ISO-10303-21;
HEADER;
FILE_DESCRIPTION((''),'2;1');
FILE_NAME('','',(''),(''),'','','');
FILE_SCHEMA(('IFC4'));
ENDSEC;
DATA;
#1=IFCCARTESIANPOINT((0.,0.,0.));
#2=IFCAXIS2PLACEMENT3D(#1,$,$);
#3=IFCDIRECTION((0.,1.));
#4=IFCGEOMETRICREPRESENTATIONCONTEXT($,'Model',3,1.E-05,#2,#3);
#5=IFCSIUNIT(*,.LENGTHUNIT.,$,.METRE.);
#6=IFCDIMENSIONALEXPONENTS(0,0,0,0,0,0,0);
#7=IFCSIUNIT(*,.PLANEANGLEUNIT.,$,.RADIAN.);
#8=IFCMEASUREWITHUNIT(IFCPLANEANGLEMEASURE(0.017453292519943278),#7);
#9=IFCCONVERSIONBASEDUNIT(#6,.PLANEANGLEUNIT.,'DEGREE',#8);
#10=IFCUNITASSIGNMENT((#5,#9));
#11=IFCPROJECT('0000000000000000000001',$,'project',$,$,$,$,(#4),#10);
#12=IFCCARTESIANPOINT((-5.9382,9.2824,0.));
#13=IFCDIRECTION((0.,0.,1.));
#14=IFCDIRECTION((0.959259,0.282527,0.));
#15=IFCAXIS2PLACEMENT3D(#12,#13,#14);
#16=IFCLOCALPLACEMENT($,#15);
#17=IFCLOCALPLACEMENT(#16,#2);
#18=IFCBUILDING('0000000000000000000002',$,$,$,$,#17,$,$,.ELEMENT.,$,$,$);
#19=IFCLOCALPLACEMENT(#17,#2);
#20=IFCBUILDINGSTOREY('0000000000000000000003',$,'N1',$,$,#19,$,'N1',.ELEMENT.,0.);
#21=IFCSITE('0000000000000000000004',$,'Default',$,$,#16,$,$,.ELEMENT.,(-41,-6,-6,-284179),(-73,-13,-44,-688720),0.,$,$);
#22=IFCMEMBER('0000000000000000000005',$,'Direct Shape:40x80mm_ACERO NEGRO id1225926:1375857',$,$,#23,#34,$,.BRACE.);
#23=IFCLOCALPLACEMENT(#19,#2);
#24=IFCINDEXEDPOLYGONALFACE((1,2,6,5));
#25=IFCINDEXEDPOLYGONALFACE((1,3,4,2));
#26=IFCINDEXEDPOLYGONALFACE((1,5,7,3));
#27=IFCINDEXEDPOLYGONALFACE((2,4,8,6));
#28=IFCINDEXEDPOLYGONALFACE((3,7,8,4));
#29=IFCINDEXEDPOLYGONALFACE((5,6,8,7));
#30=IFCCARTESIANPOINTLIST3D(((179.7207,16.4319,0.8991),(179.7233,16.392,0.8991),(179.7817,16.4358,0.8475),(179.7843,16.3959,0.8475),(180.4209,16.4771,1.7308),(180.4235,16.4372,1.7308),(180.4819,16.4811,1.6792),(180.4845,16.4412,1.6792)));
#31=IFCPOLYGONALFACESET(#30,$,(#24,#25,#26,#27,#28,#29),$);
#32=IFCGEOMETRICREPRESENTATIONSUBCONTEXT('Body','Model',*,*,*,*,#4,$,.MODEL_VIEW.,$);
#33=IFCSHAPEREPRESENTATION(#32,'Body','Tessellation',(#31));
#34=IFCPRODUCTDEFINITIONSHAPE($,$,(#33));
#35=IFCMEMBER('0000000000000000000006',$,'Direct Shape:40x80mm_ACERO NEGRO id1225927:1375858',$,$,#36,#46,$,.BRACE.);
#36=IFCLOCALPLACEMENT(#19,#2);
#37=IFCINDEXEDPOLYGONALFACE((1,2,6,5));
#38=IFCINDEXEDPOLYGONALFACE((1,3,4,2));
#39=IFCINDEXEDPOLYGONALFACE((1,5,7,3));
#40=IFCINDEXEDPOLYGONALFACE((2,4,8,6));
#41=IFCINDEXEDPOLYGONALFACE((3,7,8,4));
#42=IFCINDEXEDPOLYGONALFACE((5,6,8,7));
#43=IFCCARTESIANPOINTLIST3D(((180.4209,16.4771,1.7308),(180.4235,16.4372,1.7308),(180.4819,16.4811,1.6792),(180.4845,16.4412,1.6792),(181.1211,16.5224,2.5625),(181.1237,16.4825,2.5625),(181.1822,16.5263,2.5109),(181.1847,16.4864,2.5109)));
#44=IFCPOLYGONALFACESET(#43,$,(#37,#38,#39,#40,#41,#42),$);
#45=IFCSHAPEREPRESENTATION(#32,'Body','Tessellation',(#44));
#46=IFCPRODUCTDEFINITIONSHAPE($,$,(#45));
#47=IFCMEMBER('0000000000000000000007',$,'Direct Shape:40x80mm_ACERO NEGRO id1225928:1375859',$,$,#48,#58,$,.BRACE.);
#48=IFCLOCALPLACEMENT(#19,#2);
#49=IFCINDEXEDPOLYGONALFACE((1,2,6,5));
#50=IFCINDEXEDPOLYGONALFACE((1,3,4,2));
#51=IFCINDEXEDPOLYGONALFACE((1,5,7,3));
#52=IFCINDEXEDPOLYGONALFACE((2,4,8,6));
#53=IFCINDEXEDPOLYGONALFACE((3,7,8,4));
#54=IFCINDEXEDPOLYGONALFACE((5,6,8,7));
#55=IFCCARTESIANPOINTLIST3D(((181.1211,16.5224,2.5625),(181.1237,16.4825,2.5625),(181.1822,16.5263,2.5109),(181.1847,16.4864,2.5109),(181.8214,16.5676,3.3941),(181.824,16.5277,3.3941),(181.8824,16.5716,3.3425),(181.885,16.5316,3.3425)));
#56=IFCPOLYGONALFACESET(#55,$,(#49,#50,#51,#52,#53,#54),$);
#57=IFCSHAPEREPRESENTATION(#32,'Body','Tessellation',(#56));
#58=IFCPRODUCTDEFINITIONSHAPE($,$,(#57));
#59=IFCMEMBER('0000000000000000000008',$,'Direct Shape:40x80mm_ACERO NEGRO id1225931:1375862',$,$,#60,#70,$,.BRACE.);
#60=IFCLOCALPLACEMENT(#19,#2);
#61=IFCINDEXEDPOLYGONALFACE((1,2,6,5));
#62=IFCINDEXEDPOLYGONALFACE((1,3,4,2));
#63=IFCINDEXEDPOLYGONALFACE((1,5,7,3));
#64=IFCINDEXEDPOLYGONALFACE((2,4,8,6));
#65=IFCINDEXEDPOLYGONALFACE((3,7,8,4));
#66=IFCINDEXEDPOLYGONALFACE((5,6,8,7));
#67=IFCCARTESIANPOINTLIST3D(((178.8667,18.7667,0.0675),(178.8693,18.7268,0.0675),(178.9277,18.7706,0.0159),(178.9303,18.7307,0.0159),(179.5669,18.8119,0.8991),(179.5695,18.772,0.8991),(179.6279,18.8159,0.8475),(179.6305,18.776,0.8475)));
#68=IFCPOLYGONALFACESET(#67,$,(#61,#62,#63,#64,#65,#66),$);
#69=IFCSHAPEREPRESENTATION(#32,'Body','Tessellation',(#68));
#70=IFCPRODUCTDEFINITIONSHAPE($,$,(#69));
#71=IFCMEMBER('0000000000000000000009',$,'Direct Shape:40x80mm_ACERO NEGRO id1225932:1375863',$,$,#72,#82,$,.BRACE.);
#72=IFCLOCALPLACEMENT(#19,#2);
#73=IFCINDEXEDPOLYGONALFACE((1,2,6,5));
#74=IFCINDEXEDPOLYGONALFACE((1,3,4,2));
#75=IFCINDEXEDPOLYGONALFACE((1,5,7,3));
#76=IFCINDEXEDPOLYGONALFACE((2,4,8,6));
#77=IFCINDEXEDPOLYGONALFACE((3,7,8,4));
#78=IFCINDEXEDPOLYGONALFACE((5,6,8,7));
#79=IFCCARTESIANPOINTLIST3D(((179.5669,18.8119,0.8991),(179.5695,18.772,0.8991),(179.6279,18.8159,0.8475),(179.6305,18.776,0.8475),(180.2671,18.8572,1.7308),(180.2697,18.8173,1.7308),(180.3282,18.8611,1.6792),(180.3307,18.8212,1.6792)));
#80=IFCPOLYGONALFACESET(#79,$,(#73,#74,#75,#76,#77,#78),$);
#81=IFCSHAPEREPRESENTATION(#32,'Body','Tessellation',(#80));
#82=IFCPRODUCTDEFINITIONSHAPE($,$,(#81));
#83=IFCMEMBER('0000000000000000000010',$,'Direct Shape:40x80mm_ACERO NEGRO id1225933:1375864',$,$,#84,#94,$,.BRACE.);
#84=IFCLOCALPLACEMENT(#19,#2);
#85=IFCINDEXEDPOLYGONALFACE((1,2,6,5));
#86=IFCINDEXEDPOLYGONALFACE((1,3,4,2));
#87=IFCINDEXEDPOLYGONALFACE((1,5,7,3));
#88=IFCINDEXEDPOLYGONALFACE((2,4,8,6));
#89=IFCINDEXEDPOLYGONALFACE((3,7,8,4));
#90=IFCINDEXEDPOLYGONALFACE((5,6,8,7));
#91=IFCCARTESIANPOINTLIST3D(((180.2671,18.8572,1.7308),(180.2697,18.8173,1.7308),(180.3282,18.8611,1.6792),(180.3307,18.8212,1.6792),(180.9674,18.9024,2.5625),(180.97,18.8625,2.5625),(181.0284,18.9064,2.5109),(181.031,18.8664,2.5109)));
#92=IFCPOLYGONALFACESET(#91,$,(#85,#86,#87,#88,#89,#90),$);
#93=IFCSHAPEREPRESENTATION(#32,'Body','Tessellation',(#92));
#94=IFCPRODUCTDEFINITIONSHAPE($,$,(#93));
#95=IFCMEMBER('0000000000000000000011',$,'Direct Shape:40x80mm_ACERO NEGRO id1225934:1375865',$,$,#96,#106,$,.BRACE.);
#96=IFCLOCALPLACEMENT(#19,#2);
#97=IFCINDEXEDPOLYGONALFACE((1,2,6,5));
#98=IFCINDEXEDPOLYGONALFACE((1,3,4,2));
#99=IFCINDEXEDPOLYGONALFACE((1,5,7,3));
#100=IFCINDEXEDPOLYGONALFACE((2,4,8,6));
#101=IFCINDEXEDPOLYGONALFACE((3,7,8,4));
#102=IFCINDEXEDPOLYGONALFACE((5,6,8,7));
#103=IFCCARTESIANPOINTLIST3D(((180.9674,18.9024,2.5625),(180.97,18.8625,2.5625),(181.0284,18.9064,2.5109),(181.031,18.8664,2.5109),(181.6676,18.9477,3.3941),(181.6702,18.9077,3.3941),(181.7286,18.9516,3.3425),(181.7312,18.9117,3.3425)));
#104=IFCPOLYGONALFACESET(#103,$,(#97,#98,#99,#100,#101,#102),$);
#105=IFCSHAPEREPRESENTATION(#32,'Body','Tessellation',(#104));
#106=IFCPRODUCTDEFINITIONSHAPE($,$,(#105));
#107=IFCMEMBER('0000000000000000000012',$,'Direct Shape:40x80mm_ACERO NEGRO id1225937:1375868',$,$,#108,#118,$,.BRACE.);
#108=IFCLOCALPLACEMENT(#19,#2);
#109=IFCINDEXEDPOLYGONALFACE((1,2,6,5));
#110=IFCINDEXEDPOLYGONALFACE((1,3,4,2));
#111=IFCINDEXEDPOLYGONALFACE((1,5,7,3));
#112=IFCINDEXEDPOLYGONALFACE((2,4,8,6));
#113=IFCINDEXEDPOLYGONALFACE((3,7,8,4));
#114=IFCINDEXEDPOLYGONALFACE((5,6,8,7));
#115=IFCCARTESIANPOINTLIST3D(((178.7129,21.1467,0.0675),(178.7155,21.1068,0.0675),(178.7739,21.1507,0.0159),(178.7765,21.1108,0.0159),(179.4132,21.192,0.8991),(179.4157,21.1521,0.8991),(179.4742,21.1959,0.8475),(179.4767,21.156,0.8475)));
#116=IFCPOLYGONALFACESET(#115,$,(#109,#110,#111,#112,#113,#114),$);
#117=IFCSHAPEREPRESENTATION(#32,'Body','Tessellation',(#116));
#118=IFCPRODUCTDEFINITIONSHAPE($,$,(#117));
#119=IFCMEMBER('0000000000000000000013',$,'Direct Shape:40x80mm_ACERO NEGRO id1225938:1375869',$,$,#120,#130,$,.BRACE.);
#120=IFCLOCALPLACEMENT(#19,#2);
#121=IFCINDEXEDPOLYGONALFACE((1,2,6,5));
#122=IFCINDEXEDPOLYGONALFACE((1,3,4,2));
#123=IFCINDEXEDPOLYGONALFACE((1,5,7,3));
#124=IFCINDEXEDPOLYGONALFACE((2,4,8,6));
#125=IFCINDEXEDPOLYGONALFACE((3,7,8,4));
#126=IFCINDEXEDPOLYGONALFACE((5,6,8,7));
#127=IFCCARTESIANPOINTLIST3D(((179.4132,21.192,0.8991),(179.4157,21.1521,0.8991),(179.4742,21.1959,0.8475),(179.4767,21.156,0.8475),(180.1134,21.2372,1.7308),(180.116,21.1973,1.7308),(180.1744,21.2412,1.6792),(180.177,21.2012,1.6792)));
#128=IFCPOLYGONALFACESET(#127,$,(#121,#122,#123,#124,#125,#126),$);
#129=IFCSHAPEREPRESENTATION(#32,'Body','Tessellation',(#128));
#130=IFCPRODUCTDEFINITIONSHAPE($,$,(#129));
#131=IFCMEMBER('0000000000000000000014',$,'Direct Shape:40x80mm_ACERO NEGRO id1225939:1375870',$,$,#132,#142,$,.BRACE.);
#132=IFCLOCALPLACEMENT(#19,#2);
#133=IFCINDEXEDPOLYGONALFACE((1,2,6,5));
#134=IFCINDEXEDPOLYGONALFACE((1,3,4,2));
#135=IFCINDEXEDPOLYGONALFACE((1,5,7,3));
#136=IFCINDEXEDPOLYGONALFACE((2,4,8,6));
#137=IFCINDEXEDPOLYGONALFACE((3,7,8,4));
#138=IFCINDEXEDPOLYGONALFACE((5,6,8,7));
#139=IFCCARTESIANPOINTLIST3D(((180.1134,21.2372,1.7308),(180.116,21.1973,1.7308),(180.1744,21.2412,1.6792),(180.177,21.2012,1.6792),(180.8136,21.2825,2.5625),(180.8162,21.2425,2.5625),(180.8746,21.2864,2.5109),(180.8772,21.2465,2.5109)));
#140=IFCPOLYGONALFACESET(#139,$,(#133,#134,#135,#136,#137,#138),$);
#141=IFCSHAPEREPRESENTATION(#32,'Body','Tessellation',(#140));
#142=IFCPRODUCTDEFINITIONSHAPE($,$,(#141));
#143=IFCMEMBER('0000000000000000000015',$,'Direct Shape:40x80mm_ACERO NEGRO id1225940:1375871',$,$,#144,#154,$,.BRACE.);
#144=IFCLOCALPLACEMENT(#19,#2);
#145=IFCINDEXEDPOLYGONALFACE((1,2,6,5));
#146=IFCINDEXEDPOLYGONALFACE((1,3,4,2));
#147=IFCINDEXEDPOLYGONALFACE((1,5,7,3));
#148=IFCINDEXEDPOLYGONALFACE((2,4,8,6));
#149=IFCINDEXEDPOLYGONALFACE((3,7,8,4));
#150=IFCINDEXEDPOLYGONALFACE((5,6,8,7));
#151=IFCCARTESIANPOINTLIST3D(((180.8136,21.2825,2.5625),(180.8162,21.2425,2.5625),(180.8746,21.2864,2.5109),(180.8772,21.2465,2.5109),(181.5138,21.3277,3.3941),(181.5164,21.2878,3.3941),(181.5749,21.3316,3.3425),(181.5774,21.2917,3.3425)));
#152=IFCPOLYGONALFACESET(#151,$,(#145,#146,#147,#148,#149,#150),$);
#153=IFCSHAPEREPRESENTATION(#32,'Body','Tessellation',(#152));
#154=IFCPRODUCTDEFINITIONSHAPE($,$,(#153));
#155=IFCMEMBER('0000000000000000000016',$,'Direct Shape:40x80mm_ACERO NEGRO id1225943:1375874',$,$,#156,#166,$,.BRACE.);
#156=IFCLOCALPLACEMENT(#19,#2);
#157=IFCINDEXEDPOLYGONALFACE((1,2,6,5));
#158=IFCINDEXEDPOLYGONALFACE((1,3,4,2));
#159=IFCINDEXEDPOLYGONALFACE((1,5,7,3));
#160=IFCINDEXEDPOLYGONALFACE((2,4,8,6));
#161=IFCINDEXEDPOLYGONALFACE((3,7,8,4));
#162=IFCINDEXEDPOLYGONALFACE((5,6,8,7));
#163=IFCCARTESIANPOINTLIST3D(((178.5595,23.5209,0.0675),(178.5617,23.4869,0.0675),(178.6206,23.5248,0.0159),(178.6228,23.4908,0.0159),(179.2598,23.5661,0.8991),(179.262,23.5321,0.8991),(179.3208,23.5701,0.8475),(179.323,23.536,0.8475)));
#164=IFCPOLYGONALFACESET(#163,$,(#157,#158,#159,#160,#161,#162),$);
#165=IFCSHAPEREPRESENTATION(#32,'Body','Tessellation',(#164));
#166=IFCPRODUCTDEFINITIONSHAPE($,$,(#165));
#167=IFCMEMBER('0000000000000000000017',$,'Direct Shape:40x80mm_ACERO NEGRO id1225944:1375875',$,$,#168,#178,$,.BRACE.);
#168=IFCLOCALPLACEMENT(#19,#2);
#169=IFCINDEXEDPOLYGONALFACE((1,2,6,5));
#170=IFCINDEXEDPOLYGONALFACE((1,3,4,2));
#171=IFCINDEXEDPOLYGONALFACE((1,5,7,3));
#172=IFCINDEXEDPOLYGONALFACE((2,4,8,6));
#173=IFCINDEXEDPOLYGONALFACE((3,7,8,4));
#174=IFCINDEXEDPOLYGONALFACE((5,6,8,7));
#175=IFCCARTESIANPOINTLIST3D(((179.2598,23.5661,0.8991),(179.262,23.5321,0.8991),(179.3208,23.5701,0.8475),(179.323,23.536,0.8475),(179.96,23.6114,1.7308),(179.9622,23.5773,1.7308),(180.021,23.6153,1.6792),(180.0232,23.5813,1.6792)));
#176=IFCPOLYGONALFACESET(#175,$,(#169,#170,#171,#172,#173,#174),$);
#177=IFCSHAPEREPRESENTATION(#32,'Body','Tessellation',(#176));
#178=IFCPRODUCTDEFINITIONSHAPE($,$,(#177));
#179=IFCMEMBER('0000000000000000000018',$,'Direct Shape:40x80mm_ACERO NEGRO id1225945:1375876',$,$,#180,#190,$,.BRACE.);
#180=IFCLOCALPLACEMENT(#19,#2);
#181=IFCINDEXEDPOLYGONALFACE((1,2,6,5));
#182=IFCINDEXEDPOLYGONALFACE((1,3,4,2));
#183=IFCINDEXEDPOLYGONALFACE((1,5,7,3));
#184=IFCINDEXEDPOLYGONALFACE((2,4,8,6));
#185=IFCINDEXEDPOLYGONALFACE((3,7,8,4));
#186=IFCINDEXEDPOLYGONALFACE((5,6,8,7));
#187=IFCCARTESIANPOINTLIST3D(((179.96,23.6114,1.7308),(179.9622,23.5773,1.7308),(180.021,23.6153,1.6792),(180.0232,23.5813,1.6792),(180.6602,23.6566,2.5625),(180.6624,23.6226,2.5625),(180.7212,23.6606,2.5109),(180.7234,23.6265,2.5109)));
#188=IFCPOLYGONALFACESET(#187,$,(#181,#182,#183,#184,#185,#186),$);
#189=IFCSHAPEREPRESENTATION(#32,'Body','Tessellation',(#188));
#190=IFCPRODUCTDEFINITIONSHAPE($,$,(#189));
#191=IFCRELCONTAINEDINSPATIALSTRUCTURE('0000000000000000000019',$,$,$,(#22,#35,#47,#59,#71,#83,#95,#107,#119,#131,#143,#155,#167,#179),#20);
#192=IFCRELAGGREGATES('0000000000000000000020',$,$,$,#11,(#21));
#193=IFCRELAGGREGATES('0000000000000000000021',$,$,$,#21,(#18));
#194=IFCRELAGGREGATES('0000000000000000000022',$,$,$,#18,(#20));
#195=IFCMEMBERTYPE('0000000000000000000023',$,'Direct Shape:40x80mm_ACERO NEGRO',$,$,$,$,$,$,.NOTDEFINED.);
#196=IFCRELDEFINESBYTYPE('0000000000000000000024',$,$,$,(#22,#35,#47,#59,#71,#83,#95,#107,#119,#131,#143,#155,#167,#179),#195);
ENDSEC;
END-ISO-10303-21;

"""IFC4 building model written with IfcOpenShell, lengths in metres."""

from ifc_helpers import new_model, entity, si_unit, converted_unit, direction, frame, frame_2d, origin, place, context, subcontext, project, spatial, rectangle, extrude, type_object, element, save


model = new_model("IFC4")

# Units and contexts
model_context = context("Model", 3, precision=1e-05, world=origin(), true_north=direction((0.0, 1.0)))
body_context = subcontext(model_context, "Body", "Model", "MODEL_VIEW")
ifc_project = project(units=[si_unit("LENGTHUNIT", "METRE"), converted_unit("PLANEANGLEUNIT", "DEGREE", entity("IfcPlaneAngleMeasure", 0.017453292519943278), si_unit("PLANEANGLEUNIT", "RADIAN"), dimensions=[0, 0, 0, 0, 0, 0, 0])], contexts=[model_context])

# Site, building, storey
site_placement = place(None, frame((-5.9382, 9.2824, 0.0), z_axis=(0.0, 0.0, 1.0), x_axis=(0.959259, 0.282527, 0.0)))
site = spatial("IfcSite", under=ifc_project, at=site_placement, Name="Default", CompositionType="ELEMENT", RefLatitude=(-41, -6, -6, -284179), RefLongitude=(-73, -13, -44, -688720), RefElevation=0.0)
building_placement = place(site_placement, origin())
building = spatial("IfcBuilding", under=site, at=building_placement, CompositionType="ELEMENT")
storey_placement = place(building_placement, origin())
storey = spatial("IfcBuildingStorey", under=building, at=storey_placement, Name="N1", LongName="N1", CompositionType="ELEMENT", Elevation=0.0)

# Members
member_type_1 = type_object("IfcMemberType", Name="Direct Shape:40x80mm_ACERO NEGRO", PredefinedType="NOTDEFINED")
member_1_placement = place(storey_placement, origin())
element("IfcMember", 1, at=member_1_placement, inside=storey, type_object=member_type_1, Name="Direct Shape:40x80mm_ACERO NEGRO id1225926:1375857", PredefinedType="BRACE", context=body_context, shape_type="SweptSolid", body=[
    extrude(rectangle(XDim=0.08, YDim=0.04, at=frame_2d((0.0, 0.0), x_axis=(0.0, 1.0))), frame((179.7525, 16.4139, 0.8733), z_axis=(0.643515, 0.041575, 0.764304), x_axis=(0.064471, -0.99792, 0.0)), (0.0, 0.0, 1.0), 1.0881),
])
member_2_placement = place(storey_placement, origin())
element("IfcMember", 2, at=member_2_placement, inside=storey, type_object=member_type_1, Name="Direct Shape:40x80mm_ACERO NEGRO id1225927:1375858", PredefinedType="BRACE", context=body_context, shape_type="SweptSolid", body=[
    extrude(rectangle(XDim=0.08, YDim=0.04, at=frame_2d((0.0, 0.0), x_axis=(0.0, 1.0))), frame((180.4527, 16.4592, 1.705), z_axis=(0.643515, 0.041575, 0.764304), x_axis=(0.064471, -0.99792, 0.0)), (0.0, 0.0, 1.0), 1.0881),
])
member_3_placement = place(storey_placement, origin())
element("IfcMember", 3, at=member_3_placement, inside=storey, type_object=member_type_1, Name="Direct Shape:40x80mm_ACERO NEGRO id1225928:1375859", PredefinedType="BRACE", context=body_context, shape_type="SweptSolid", body=[
    extrude(rectangle(XDim=0.08, YDim=0.04, at=frame_2d((0.0, 0.0), x_axis=(0.0, 1.0))), frame((181.1529, 16.5044, 2.5367), z_axis=(0.643515, 0.041575, 0.764304), x_axis=(0.064471, -0.99792, 0.0)), (0.0, 0.0, 1.0), 1.0881),
])
member_4_placement = place(storey_placement, origin())
element("IfcMember", 4, at=member_4_placement, inside=storey, type_object=member_type_1, Name="Direct Shape:40x80mm_ACERO NEGRO id1225931:1375862", PredefinedType="BRACE", context=body_context, shape_type="SweptSolid", body=[
    extrude(rectangle(XDim=0.08, YDim=0.04, at=frame_2d((0.0, 0.0), x_axis=(0.0, 1.0))), frame((178.8985, 18.7487, 0.0417), z_axis=(0.643515, 0.041575, 0.764304), x_axis=(0.064471, -0.99792, 0.0)), (0.0, 0.0, 1.0), 1.0881),
])
member_5_placement = place(storey_placement, origin())
element("IfcMember", 5, at=member_5_placement, inside=storey, type_object=member_type_1, Name="Direct Shape:40x80mm_ACERO NEGRO id1225932:1375863", PredefinedType="BRACE", context=body_context, shape_type="SweptSolid", body=[
    extrude(rectangle(XDim=0.08, YDim=0.04, at=frame_2d((0.0, 0.0), x_axis=(0.0, 1.0))), frame((179.5987, 18.794, 0.8733), z_axis=(0.643515, 0.041575, 0.764304), x_axis=(0.064471, -0.99792, 0.0)), (0.0, 0.0, 1.0), 1.0881),
])
member_6_placement = place(storey_placement, origin())
element("IfcMember", 6, at=member_6_placement, inside=storey, type_object=member_type_1, Name="Direct Shape:40x80mm_ACERO NEGRO id1225933:1375864", PredefinedType="BRACE", context=body_context, shape_type="SweptSolid", body=[
    extrude(rectangle(XDim=0.08, YDim=0.04, at=frame_2d((0.0, 0.0), x_axis=(0.0, 1.0))), frame((180.2989, 18.8392, 1.705), z_axis=(0.643515, 0.041575, 0.764304), x_axis=(0.064471, -0.99792, 0.0)), (0.0, 0.0, 1.0), 1.0881),
])
member_7_placement = place(storey_placement, origin())
element("IfcMember", 7, at=member_7_placement, inside=storey, type_object=member_type_1, Name="Direct Shape:40x80mm_ACERO NEGRO id1225934:1375865", PredefinedType="BRACE", context=body_context, shape_type="SweptSolid", body=[
    extrude(rectangle(XDim=0.08, YDim=0.04, at=frame_2d((0.0, 0.0), x_axis=(0.0, 1.0))), frame((180.9992, 18.8844, 2.5367), z_axis=(0.643515, 0.041575, 0.764304), x_axis=(0.064471, -0.99792, 0.0)), (0.0, 0.0, 1.0), 1.0881),
])
member_8_placement = place(storey_placement, origin())
element("IfcMember", 8, at=member_8_placement, inside=storey, type_object=member_type_1, Name="Direct Shape:40x80mm_ACERO NEGRO id1225937:1375868", PredefinedType="BRACE", context=body_context, shape_type="SweptSolid", body=[
    extrude(rectangle(XDim=0.08, YDim=0.04, at=frame_2d((0.0, 0.0), x_axis=(0.0, 1.0))), frame((178.7447, 21.1288, 0.0417), z_axis=(0.643515, 0.041575, 0.764304), x_axis=(0.064471, -0.99792, 0.0)), (0.0, 0.0, 1.0), 1.0881),
])
member_9_placement = place(storey_placement, origin())
element("IfcMember", 9, at=member_9_placement, inside=storey, type_object=member_type_1, Name="Direct Shape:40x80mm_ACERO NEGRO id1225938:1375869", PredefinedType="BRACE", context=body_context, shape_type="SweptSolid", body=[
    extrude(rectangle(XDim=0.08, YDim=0.04, at=frame_2d((0.0, 0.0), x_axis=(0.0, 1.0))), frame((179.4449, 21.174, 0.8733), z_axis=(0.643515, 0.041575, 0.764304), x_axis=(0.064471, -0.99792, 0.0)), (0.0, 0.0, 1.0), 1.0881),
])
member_10_placement = place(storey_placement, origin())
element("IfcMember", 10, at=member_10_placement, inside=storey, type_object=member_type_1, Name="Direct Shape:40x80mm_ACERO NEGRO id1225939:1375870", PredefinedType="BRACE", context=body_context, shape_type="SweptSolid", body=[
    extrude(rectangle(XDim=0.08, YDim=0.04, at=frame_2d((0.0, 0.0), x_axis=(0.0, 1.0))), frame((180.1452, 21.2192, 1.705), z_axis=(0.643515, 0.041575, 0.764304), x_axis=(0.064471, -0.99792, 0.0)), (0.0, 0.0, 1.0), 1.0881),
])
member_11_placement = place(storey_placement, origin())
element("IfcMember", 11, at=member_11_placement, inside=storey, type_object=member_type_1, Name="Direct Shape:40x80mm_ACERO NEGRO id1225940:1375871", PredefinedType="BRACE", context=body_context, shape_type="SweptSolid", body=[
    extrude(rectangle(XDim=0.08, YDim=0.04, at=frame_2d((0.0, 0.0), x_axis=(0.0, 1.0))), frame((180.8454, 21.2645, 2.5367), z_axis=(0.643515, 0.041575, 0.764304), x_axis=(0.064471, -0.99792, 0.0)), (0.0, 0.0, 1.0), 1.0881),
])
member_12_placement = place(storey_placement, origin())
element("IfcMember", 12, at=member_12_placement, inside=storey, type_object=member_type_1, Name="Direct Shape:40x80mm_ACERO NEGRO id1225943:1375874", PredefinedType="BRACE", context=body_context, shape_type="SweptSolid", body=[
    extrude(rectangle(XDim=0.08, YDim=0.0341, at=frame_2d((0.0, 0.0), x_axis=(0.0, 1.0))), frame((178.5911, 23.5059, 0.0417), z_axis=(0.643515, 0.041575, 0.764304), x_axis=(0.064471, -0.99792, 0.0)), (0.0, 0.0, 1.0), 1.0881),
])
member_13_placement = place(storey_placement, origin())
element("IfcMember", 13, at=member_13_placement, inside=storey, type_object=member_type_1, Name="Direct Shape:40x80mm_ACERO NEGRO id1225944:1375875", PredefinedType="BRACE", context=body_context, shape_type="SweptSolid", body=[
    extrude(rectangle(XDim=0.08, YDim=0.0341, at=frame_2d((0.0, 0.0), x_axis=(0.0, 1.0))), frame((179.2914, 23.5511, 0.8733), z_axis=(0.643515, 0.041575, 0.764304), x_axis=(0.064471, -0.99792, 0.0)), (0.0, 0.0, 1.0), 1.0881),
])
member_14_placement = place(storey_placement, origin())
element("IfcMember", 14, at=member_14_placement, inside=storey, type_object=member_type_1, Name="Direct Shape:40x80mm_ACERO NEGRO id1225945:1375876", PredefinedType="BRACE", context=body_context, shape_type="SweptSolid", body=[
    extrude(rectangle(XDim=0.08, YDim=0.0341, at=frame_2d((0.0, 0.0), x_axis=(0.0, 1.0))), frame((179.9916, 23.5963, 1.705), z_axis=(0.643515, 0.041575, 0.764304), x_axis=(0.064471, -0.99792, 0.0)), (0.0, 0.0, 1.0), 1.0881),
])

save(model, "model.ifc")
